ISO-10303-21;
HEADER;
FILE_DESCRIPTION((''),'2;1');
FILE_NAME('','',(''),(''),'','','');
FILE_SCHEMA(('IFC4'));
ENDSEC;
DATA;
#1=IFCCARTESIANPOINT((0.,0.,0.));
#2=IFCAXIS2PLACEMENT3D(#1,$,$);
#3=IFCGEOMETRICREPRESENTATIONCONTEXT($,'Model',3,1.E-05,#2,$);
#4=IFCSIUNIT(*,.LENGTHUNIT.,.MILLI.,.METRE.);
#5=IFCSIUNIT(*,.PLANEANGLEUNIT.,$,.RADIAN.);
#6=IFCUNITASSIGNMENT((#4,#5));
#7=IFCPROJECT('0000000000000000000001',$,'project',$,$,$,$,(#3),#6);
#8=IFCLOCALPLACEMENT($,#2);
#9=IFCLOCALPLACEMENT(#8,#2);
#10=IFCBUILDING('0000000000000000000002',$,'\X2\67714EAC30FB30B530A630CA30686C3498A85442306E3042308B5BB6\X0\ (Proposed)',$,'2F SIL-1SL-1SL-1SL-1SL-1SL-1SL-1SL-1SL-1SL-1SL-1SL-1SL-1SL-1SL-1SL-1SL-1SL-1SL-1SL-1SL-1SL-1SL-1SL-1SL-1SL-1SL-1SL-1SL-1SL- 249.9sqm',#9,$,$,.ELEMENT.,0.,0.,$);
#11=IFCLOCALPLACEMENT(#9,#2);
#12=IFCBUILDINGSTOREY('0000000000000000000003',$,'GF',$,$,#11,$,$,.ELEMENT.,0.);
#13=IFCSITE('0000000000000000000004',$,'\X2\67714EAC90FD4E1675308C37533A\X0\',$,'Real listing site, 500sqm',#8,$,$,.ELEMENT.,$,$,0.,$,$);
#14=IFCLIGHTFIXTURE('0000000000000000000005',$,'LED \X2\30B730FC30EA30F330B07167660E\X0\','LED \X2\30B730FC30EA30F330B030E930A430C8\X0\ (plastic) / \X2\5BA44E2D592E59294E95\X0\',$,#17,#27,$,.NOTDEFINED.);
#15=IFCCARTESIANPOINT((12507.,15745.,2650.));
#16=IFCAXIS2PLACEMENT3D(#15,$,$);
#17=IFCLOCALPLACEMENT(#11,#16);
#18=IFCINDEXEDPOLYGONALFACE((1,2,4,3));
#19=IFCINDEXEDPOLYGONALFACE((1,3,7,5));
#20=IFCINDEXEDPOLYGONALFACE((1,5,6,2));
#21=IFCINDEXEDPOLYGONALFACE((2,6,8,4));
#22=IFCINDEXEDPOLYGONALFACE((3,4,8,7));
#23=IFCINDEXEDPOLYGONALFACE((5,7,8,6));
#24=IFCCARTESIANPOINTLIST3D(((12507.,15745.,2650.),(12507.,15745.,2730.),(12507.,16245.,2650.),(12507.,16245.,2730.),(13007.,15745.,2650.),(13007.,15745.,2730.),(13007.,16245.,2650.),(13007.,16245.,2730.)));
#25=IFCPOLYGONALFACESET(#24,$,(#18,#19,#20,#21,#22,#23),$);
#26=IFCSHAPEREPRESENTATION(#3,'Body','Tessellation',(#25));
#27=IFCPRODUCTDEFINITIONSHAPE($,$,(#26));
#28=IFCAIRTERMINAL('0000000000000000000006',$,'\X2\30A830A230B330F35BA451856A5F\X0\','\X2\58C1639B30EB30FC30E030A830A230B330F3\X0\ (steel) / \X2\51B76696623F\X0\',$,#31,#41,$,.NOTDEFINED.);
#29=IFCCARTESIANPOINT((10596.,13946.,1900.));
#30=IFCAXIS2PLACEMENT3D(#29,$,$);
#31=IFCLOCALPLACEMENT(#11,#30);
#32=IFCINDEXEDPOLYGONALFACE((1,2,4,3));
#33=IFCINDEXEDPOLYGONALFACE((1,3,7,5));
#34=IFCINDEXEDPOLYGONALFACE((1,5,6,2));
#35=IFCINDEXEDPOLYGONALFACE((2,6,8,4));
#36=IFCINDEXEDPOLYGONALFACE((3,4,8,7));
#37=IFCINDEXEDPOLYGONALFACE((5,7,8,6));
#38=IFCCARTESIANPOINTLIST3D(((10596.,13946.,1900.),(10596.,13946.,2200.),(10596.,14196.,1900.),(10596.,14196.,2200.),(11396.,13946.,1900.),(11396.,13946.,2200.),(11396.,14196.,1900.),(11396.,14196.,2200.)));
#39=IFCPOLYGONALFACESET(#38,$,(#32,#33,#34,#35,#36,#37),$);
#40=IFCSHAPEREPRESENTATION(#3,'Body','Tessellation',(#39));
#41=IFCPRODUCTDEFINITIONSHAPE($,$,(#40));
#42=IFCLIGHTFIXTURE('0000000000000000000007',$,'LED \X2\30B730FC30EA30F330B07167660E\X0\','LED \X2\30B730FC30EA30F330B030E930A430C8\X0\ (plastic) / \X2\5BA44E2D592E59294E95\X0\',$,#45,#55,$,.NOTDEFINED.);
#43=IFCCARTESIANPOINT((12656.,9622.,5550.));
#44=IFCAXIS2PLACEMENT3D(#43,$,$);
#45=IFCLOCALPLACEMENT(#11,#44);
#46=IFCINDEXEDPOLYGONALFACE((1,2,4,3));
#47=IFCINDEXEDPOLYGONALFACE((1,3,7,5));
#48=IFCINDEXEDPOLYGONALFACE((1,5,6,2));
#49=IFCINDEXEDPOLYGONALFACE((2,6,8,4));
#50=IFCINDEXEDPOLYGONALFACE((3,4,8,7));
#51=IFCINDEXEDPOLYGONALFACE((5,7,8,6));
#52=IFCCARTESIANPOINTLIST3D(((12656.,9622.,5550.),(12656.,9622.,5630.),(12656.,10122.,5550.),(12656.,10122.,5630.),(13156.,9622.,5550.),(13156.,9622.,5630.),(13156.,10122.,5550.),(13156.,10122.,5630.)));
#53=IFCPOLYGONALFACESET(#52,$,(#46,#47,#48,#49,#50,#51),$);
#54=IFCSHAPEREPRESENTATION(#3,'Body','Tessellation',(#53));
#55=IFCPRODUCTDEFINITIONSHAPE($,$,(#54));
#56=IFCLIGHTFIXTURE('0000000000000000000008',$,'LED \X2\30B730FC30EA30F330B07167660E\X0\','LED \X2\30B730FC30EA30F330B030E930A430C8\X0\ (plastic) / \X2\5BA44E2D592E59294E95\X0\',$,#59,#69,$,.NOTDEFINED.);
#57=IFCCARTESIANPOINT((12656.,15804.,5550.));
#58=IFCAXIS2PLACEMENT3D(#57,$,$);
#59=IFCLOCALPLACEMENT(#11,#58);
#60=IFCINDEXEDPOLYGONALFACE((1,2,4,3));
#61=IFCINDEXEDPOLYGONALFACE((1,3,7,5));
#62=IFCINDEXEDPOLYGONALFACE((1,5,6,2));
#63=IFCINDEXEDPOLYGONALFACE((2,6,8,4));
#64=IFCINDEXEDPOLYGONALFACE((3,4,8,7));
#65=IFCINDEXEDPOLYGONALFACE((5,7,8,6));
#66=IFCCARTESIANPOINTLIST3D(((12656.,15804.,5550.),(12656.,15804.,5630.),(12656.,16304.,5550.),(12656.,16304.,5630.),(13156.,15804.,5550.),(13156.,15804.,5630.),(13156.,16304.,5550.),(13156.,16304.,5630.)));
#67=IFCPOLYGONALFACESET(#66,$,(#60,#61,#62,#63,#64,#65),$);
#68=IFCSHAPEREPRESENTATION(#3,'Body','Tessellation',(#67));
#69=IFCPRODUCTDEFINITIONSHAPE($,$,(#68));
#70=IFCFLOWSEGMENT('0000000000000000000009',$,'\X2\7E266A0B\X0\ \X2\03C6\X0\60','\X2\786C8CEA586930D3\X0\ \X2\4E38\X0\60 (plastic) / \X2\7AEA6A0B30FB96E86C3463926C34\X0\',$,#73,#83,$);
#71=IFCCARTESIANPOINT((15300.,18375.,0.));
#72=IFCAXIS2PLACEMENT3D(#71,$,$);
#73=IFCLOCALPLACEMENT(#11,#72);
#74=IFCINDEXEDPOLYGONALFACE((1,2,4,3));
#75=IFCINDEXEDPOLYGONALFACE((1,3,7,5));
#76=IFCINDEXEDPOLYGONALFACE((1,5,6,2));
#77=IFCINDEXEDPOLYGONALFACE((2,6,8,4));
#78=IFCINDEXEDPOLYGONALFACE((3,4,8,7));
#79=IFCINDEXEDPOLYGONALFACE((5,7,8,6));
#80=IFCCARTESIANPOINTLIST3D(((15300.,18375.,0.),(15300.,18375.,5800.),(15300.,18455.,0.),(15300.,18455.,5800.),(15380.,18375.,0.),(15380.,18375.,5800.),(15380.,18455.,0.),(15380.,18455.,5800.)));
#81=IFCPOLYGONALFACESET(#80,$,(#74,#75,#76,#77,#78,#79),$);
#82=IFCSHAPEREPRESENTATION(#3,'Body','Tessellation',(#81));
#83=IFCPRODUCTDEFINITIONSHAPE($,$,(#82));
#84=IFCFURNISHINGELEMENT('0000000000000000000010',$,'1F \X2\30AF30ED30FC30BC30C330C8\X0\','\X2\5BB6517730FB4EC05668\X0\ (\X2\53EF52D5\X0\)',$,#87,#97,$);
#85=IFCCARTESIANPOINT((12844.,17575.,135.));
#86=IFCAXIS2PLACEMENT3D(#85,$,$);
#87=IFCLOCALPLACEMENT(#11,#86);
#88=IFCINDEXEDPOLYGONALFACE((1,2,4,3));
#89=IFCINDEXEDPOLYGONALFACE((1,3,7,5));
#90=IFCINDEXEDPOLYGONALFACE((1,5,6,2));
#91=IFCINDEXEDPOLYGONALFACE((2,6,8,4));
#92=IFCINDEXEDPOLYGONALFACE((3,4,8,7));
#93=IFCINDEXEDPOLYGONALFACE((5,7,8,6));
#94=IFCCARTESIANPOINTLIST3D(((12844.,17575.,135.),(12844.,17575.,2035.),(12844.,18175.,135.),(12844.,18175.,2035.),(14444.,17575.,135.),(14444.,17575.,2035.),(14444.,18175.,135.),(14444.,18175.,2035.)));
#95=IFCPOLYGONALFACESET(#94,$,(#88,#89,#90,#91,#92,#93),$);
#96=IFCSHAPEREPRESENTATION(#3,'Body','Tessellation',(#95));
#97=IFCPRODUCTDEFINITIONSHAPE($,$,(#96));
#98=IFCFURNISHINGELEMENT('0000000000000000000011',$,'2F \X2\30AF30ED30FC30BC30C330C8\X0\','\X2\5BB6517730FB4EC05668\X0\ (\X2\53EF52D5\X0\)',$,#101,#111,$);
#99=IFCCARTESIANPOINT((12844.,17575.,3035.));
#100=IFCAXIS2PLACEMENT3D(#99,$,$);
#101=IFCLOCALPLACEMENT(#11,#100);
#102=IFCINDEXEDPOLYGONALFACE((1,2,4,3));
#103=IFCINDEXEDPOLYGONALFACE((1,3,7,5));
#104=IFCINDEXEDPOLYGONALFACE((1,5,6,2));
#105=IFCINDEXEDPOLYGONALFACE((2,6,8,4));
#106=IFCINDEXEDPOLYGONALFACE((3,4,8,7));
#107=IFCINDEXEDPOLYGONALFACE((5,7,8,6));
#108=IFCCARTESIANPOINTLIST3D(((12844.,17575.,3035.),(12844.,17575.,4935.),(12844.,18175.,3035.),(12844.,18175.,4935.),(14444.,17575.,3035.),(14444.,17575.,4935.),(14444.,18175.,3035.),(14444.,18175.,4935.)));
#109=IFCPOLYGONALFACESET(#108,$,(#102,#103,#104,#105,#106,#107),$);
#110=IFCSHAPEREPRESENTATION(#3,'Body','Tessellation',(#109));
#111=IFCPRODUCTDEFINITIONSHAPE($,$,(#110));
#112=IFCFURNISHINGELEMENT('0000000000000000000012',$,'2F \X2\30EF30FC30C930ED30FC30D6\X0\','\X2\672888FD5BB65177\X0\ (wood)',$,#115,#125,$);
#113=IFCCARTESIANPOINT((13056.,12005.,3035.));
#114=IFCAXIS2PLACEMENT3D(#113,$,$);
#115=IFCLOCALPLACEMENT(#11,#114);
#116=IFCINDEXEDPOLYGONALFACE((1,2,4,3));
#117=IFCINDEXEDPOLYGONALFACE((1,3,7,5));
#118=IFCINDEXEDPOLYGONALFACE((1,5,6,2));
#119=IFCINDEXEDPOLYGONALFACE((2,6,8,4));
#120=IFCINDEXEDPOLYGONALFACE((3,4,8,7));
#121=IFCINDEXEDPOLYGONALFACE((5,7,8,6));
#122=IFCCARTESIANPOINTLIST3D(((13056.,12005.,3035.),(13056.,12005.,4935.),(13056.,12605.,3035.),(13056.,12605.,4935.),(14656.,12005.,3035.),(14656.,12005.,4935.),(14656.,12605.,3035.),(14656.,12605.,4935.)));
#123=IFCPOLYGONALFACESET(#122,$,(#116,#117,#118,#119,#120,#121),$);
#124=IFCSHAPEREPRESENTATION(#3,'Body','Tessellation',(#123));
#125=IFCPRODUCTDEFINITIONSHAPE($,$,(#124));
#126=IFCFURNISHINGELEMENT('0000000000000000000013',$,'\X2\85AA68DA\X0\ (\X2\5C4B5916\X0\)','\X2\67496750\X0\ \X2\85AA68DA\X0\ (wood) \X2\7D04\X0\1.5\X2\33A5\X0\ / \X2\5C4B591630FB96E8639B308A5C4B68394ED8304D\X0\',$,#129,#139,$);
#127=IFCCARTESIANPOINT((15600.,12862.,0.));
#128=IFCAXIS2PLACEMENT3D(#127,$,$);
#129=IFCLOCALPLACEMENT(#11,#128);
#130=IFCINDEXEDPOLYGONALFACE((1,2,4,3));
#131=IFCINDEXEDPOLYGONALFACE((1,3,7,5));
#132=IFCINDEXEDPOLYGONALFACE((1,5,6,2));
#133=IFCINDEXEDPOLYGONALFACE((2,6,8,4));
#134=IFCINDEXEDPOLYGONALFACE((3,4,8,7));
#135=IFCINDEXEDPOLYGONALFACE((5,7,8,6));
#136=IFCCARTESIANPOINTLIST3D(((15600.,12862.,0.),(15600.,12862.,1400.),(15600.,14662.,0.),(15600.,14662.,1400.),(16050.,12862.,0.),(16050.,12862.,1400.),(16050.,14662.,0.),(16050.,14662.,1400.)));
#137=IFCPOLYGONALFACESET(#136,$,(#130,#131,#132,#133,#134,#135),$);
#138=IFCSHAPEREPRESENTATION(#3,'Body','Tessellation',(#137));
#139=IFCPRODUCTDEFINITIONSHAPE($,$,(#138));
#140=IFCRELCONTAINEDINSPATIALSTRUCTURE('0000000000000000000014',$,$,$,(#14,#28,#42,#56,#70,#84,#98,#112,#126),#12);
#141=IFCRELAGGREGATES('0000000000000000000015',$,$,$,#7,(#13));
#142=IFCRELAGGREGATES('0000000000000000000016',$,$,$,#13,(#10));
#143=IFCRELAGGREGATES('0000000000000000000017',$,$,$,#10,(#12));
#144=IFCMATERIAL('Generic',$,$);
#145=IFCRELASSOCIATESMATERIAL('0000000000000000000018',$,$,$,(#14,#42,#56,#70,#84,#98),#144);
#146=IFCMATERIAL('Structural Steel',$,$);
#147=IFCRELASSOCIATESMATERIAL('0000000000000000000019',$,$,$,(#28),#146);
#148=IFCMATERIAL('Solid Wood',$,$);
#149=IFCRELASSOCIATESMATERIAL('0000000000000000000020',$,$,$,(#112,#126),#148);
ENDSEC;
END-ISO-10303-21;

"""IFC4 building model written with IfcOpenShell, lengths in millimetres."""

from ifc_helpers import new_model, si_unit, frame, frame_2d, origin, place, context, project, spatial, rectangle, extrude, material, element, save


model = new_model("IFC4")

# Units and contexts
model_context = context("Model", 3, precision=1e-05, world=origin())
ifc_project = project(units=[si_unit("LENGTHUNIT", "METRE", prefix="MILLI"), si_unit("PLANEANGLEUNIT", "RADIAN")], contexts=[model_context])

# Site, building, storey
site_placement = place(None, origin())
site = spatial("IfcSite", under=ifc_project, at=site_placement, Name="東京都世田谷区", ObjectType="Real listing site, 500sqm", CompositionType="ELEMENT", RefElevation=0.0)
building_placement = place(site_placement, origin())
building = spatial("IfcBuilding", under=site, at=building_placement, Name="東京・サウナと水風呂のある家 (Proposed)", ObjectType="2F SIL-1SL-1SL-1SL-1SL-1SL-1SL-1SL-1SL-1SL-1SL-1SL-1SL-1SL-1SL-1SL-1SL-1SL-1SL-1SL-1SL-1SL-1SL-1SL-1SL-1SL-1SL-1SL-1SL-1SL- 249.9sqm", CompositionType="ELEMENT", ElevationOfRefHeight=0.0, ElevationOfTerrain=0.0)
storey_placement = place(building_placement, origin())
storey = spatial("IfcBuildingStorey", under=building, at=storey_placement, Name="GF", CompositionType="ELEMENT", Elevation=0.0)

# Shared definitions
ifc_material_1 = material(Name="Solid Wood")

# Shared definitions
ifc_material_2 = material(Name="Structural Steel")

# Shared definitions
ifc_material_3 = material(Name="Generic")

# Light fixture
light_fixture_1_placement = place(storey_placement, frame((12507.0, 15745.0, 2650.0)))
element("IfcLightFixture", 1, at=light_fixture_1_placement, inside=storey, material=ifc_material_3, Name="LED シーリング照明", Description="LED シーリングライト (plastic) / 室中央天井", PredefinedType="NOTDEFINED", context=model_context, shape_type="SweptSolid", body=[
    extrude(rectangle(XDim=500.0, YDim=500.0, at=frame_2d((250.0, 250.0))), frame((12507.0, 15745.0, 2650.0)), (0.0, 0.0, 1.0), 80.0),
])

# Air terminal
air_terminal_placement = place(storey_placement, frame((10596.0, 13946.0, 1900.0)))
element("IfcAirTerminal", 2, at=air_terminal_placement, inside=storey, material=ifc_material_2, Name="エアコン室内機", Description="壁掛ルームエアコン (steel) / 冷暖房", PredefinedType="NOTDEFINED", context=model_context, shape_type="SweptSolid", body=[
    extrude(rectangle(XDim=800.0, YDim=250.0, at=frame_2d((400.0, 125.0))), frame((10596.0, 13946.0, 1900.0)), (0.0, 0.0, 1.0), 300.0),
])

# Light fixtures
light_fixture_2_placement = place(storey_placement, frame((12656.0, 9622.0, 5550.0)))
element("IfcLightFixture", 3, at=light_fixture_2_placement, inside=storey, material=ifc_material_3, Name="LED シーリング照明", Description="LED シーリングライト (plastic) / 室中央天井", PredefinedType="NOTDEFINED", context=model_context, shape_type="SweptSolid", body=[
    extrude(rectangle(XDim=500.0, YDim=500.0, at=frame_2d((250.0, 250.0))), frame((12656.0, 9622.0, 5550.0)), (0.0, 0.0, 1.0), 80.0),
])
light_fixture_3_placement = place(storey_placement, frame((12656.0, 15804.0, 5550.0)))
element("IfcLightFixture", 4, at=light_fixture_3_placement, inside=storey, material=ifc_material_3, Name="LED シーリング照明", Description="LED シーリングライト (plastic) / 室中央天井", PredefinedType="NOTDEFINED", context=model_context, shape_type="SweptSolid", body=[
    extrude(rectangle(XDim=500.0, YDim=500.0, at=frame_2d((250.0, 250.0))), frame((12656.0, 15804.0, 5550.0)), (0.0, 0.0, 1.0), 80.0),
])

# Flow segment
flow_segment_placement = place(storey_placement, frame((15300.0, 18375.0, 0.0)))
element("IfcFlowSegment", 5, at=flow_segment_placement, inside=storey, material=ifc_material_3, Name="縦樋 φ60", Description="硬質塩ビ 丸60 (plastic) / 竪樋・雨水排水", context=model_context, shape_type="SweptSolid", body=[
    extrude(rectangle(XDim=80.0, YDim=80.0, at=frame_2d((40.0, 40.0))), frame((15300.0, 18375.0, 0.0)), (0.0, 0.0, 1.0), 5800.0),
])

# Furnishing elements
furnishing_1_placement = place(storey_placement, frame((12844.0, 17575.0, 135.0)))
element("IfcFurnishingElement", 6, at=furnishing_1_placement, inside=storey, material=ifc_material_3, Name="1F クローゼット", Description="家具・什器 (可動)", context=model_context, shape_type="SweptSolid", body=[
    extrude(rectangle(XDim=1600.0, YDim=600.0, at=frame_2d((800.0, 300.0))), frame((12844.0, 17575.0, 135.0)), (0.0, 0.0, 1.0), 1900.0),
])
furnishing_2_placement = place(storey_placement, frame((12844.0, 17575.0, 3035.0)))
element("IfcFurnishingElement", 7, at=furnishing_2_placement, inside=storey, material=ifc_material_3, Name="2F クローゼット", Description="家具・什器 (可動)", context=model_context, shape_type="SweptSolid", body=[
    extrude(rectangle(XDim=1600.0, YDim=600.0, at=frame_2d((800.0, 300.0))), frame((12844.0, 17575.0, 3035.0)), (0.0, 0.0, 1.0), 1900.0),
])
furnishing_3_placement = place(storey_placement, frame((13056.0, 12005.0, 3035.0)))
element("IfcFurnishingElement", 8, at=furnishing_3_placement, inside=storey, material=ifc_material_1, Name="2F ワードローブ", Description="木製家具 (wood)", context=model_context, shape_type="SweptSolid", body=[
    extrude(rectangle(XDim=1600.0, YDim=600.0, at=frame_2d((800.0, 300.0))), frame((13056.0, 12005.0, 3035.0)), (0.0, 0.0, 1.0), 1900.0),
])
furnishing_4_placement = place(storey_placement, frame((15600.0, 12862.0, 0.0)))
element("IfcFurnishingElement", 9, at=furnishing_4_placement, inside=storey, material=ifc_material_1, Name="薪棚 (屋外)", Description="杉材 薪棚 (wood) 約1.5㎥ / 屋外・雨掛り屋根付き", context=model_context, shape_type="SweptSolid", body=[
    extrude(rectangle(XDim=450.0, YDim=1800.0, at=frame_2d((225.0, 900.0))), frame((15600.0, 12862.0, 0.0)), (0.0, 0.0, 1.0), 1400.0),
])

save(model, "model.ifc")
